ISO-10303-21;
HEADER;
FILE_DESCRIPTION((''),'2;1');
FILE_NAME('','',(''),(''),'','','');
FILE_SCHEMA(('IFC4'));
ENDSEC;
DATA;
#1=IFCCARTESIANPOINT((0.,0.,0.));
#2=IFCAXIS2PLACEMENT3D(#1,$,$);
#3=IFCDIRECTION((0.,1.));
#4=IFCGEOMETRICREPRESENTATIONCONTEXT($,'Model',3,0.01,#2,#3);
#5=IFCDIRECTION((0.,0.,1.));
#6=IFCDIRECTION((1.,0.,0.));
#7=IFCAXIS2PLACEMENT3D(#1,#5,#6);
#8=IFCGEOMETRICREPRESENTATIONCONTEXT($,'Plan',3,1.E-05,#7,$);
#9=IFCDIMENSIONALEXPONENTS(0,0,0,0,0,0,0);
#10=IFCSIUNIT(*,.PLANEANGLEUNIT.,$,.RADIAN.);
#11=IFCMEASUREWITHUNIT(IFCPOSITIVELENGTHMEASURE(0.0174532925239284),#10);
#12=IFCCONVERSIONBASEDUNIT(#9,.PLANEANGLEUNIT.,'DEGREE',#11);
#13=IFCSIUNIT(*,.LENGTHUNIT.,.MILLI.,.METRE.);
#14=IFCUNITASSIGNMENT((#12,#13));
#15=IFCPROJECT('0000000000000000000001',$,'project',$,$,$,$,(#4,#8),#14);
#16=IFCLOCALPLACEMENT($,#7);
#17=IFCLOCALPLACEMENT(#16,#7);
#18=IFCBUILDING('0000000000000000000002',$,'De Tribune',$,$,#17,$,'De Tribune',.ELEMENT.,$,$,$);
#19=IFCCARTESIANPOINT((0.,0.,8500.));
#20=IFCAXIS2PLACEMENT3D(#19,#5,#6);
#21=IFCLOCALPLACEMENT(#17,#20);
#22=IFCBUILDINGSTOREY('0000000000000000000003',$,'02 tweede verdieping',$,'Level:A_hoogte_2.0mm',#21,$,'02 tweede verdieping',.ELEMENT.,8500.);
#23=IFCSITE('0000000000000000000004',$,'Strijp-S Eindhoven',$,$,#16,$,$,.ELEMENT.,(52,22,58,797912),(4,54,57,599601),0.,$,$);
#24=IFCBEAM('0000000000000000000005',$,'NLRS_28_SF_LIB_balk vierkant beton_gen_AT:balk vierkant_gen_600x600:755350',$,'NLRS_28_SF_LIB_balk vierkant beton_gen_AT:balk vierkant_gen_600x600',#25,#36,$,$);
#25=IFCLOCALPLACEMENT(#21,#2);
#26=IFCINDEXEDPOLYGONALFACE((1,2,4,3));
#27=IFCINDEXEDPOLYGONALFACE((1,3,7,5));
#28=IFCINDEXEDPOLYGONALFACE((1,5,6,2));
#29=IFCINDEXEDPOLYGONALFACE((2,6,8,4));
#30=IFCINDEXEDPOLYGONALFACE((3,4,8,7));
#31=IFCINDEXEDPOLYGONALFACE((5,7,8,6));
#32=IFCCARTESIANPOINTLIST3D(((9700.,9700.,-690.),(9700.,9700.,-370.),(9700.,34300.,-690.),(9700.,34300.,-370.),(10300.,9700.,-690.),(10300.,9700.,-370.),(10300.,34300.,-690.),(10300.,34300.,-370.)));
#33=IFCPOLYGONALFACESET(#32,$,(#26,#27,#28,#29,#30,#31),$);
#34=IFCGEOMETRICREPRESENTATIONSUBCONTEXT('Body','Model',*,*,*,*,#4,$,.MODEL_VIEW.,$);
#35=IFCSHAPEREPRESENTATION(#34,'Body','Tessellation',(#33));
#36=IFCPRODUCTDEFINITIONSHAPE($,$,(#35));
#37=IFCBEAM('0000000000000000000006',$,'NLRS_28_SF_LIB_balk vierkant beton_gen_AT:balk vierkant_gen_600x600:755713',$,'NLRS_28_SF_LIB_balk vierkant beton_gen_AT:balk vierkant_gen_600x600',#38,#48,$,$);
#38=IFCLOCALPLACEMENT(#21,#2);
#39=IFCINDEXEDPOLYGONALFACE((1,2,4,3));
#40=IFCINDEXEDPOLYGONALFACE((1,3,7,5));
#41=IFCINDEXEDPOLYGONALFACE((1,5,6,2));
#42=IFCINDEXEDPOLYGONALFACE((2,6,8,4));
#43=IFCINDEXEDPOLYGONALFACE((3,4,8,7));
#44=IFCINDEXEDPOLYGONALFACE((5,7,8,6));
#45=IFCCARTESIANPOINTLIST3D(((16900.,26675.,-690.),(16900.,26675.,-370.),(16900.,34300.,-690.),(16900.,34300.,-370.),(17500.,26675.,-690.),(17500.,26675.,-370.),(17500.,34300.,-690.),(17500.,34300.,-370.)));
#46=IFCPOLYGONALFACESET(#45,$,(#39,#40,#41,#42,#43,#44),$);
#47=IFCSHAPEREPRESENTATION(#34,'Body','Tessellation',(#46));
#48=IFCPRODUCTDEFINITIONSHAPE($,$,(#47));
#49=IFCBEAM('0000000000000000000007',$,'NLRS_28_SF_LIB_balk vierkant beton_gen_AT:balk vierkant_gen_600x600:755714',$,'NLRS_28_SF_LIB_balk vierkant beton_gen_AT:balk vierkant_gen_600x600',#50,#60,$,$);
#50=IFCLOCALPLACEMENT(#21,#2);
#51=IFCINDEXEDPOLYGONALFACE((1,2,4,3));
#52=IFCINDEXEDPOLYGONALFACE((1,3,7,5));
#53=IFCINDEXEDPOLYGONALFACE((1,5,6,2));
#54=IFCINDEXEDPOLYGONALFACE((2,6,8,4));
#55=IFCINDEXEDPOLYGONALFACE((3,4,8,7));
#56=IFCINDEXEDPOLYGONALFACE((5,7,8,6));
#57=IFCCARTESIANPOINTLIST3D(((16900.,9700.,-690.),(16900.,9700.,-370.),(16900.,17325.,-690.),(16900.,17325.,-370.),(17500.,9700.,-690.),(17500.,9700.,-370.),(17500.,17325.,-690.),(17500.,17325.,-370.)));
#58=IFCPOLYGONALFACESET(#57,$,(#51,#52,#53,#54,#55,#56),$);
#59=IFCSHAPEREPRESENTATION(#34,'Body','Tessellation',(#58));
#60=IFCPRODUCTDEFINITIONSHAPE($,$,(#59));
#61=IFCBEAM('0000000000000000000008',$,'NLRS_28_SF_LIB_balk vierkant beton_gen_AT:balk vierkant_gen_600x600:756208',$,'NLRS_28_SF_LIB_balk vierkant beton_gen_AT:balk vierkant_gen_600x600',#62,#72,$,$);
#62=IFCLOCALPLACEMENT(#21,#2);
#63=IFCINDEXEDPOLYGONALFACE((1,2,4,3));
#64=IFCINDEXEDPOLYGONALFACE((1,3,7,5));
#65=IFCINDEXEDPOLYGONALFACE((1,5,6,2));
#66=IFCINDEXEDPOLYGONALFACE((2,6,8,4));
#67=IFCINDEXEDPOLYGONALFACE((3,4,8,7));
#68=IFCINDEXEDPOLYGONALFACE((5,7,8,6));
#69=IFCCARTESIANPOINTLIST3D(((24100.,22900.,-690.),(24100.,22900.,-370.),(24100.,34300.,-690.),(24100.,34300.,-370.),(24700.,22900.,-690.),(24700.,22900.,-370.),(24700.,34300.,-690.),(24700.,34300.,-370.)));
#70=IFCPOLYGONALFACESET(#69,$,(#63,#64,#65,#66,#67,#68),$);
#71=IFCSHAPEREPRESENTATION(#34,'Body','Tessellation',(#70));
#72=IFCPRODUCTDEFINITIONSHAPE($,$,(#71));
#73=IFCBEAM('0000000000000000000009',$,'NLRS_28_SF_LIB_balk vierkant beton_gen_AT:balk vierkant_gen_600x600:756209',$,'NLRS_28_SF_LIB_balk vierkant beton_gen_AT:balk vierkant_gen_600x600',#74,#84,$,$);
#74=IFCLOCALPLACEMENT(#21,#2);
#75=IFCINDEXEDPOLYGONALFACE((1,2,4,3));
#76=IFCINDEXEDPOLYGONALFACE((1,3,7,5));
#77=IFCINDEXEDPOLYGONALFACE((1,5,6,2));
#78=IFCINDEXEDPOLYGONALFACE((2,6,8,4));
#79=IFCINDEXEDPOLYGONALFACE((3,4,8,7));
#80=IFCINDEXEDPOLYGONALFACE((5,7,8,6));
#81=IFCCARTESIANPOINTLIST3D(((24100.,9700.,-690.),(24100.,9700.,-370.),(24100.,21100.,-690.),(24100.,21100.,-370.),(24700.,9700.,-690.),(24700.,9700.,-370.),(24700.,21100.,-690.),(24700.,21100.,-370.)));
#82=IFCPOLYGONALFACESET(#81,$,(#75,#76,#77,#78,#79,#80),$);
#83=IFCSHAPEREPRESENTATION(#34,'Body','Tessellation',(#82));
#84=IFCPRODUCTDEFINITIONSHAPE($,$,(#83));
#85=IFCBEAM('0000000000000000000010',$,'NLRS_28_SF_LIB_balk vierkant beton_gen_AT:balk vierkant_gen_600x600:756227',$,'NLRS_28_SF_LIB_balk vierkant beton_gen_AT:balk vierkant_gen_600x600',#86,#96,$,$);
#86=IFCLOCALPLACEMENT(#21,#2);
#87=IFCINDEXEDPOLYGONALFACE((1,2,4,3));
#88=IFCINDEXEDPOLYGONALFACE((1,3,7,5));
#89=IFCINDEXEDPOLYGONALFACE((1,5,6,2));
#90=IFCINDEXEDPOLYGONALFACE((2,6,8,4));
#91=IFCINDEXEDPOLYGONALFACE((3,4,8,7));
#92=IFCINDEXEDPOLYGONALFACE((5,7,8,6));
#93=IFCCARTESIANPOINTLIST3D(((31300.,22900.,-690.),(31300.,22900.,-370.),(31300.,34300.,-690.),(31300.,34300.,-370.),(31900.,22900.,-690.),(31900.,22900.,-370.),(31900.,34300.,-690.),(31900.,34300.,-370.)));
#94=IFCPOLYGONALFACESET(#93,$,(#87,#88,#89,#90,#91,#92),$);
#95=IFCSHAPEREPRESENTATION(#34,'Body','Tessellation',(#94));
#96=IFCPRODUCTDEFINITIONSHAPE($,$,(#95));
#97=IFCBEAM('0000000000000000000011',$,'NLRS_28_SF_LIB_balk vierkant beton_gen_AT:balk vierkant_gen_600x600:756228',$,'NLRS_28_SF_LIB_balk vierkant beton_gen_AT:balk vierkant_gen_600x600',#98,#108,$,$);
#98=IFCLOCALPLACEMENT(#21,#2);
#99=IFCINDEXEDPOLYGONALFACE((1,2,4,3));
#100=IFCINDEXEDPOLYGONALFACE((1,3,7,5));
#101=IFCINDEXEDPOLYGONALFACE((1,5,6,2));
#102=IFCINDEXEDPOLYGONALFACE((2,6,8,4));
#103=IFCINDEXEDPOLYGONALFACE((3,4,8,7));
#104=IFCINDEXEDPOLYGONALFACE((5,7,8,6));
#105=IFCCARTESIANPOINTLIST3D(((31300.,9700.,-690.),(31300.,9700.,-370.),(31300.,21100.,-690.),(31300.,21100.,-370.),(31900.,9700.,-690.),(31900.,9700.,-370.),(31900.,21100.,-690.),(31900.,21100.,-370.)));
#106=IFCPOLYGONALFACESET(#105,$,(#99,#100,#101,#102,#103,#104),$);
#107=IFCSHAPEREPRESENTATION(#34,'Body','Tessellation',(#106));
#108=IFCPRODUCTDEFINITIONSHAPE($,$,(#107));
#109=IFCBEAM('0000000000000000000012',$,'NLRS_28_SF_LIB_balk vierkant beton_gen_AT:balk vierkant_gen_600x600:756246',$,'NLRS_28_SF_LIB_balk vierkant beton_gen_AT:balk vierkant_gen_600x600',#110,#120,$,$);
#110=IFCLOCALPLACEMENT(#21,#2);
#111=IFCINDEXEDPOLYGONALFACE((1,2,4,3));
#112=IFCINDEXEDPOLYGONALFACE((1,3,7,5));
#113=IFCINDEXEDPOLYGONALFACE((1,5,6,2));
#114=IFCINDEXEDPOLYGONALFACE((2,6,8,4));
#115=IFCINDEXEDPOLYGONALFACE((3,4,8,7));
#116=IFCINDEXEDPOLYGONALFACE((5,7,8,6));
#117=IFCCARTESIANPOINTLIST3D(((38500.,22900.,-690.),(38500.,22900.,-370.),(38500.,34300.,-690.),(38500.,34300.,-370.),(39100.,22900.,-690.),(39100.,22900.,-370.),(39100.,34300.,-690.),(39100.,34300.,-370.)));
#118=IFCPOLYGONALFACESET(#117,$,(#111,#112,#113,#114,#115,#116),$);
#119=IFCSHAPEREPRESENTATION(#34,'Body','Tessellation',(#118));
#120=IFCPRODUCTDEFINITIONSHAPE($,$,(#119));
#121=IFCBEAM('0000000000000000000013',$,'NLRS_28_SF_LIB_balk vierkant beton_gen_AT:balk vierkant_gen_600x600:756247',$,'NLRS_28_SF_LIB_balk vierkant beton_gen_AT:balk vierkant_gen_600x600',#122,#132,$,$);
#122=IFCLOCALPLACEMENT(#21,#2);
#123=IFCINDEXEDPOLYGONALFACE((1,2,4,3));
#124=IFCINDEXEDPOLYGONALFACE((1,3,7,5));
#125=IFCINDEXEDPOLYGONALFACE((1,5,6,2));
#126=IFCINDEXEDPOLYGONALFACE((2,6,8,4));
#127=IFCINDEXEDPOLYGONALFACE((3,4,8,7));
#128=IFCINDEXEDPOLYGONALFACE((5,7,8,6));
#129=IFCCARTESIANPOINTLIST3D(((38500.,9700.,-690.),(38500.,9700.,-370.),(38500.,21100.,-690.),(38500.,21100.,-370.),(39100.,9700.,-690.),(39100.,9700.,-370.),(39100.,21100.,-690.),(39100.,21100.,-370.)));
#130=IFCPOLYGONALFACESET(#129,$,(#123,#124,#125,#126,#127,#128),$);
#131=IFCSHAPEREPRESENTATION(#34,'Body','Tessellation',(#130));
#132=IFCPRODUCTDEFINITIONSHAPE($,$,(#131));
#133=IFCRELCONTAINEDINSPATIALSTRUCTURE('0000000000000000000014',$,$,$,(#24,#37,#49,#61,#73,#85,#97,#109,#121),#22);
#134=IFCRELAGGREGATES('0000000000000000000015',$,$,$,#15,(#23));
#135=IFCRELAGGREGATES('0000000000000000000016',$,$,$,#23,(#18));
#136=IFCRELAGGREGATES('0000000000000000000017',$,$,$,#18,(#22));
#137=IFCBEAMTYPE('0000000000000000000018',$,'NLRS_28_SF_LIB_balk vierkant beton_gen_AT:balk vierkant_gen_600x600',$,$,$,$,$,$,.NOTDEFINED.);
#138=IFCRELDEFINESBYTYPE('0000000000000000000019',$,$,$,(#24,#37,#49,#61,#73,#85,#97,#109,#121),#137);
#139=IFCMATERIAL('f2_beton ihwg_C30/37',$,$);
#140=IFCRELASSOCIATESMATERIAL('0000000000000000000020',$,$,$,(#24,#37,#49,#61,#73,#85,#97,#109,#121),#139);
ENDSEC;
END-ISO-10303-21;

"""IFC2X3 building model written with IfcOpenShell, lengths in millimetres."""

from ifc_helpers import new_model, entity, si_unit, converted_unit, direction, frame, frame_2d, origin, origin_with_axes, place, context, subcontext, project, spatial, rectangle, extrude, material, type_object, element, save


model = new_model("IFC2X3")

# Units and contexts
model_context = context("Model", 3, precision=0.01, world=origin(), true_north=direction((0.0, 1.0)))
plan_context = context("Plan", 3, precision=1e-05, world=origin_with_axes())
body_context = subcontext(model_context, "Body", "Model", "MODEL_VIEW")
ifc_project = project(units=[converted_unit("PLANEANGLEUNIT", "DEGREE", entity("IfcPositiveLengthMeasure", 0.0174532925239284), si_unit("PLANEANGLEUNIT", "RADIAN"), dimensions=[0, 0, 0, 0, 0, 0, 0]), si_unit("LENGTHUNIT", "METRE", prefix="MILLI")], contexts=[model_context, plan_context])

# Site, building, storey
site_placement = place(None, origin_with_axes())
site = spatial("IfcSite", under=ifc_project, at=site_placement, Name="Strijp-S Eindhoven", CompositionType="ELEMENT", RefLatitude=(52, 22, 58, 797912), RefLongitude=(4, 54, 57, 599601), RefElevation=0.0)
building_placement = place(site_placement, origin_with_axes())
building = spatial("IfcBuilding", under=site, at=building_placement, Name="De Tribune", LongName="De Tribune", CompositionType="ELEMENT")
storey_placement = place(building_placement, frame((0.0, 0.0, 8500.0), z_axis=(0.0, 0.0, 1.0), x_axis=(1.0, 0.0, 0.0)))
storey = spatial("IfcBuildingStorey", under=building, at=storey_placement, Name="02 tweede verdieping", ObjectType="Level:A_hoogte_2.0mm", LongName="02 tweede verdieping", CompositionType="ELEMENT", Elevation=8500.0)

# Beams
ifc_material = material(Name="f2_beton ihwg_C30/37")
beam_type = type_object("IfcBeamType", Name="NLRS_28_SF_LIB_balk vierkant beton_gen_AT:balk vierkant_gen_600x600", PredefinedType="NOTDEFINED")
beam_placement = place(storey_placement, frame((10000.0, 34300.0, 0.0), z_axis=(0.0, 0.0, 1.0), x_axis=(0.0, -1.0, 0.0)))
element("IfcBeam", 1, at=beam_placement, inside=storey, type_object=beam_type, material=ifc_material, Name="NLRS_28_SF_LIB_balk vierkant beton_gen_AT:balk vierkant_gen_600x600:755350", ObjectType="NLRS_28_SF_LIB_balk vierkant beton_gen_AT:balk vierkant_gen_600x600", context=body_context, shape_type="SweptSolid", body=[
    extrude(rectangle(XDim=320.0, YDim=600.0, at=frame_2d((0.0, 0.0), x_axis=(1.0, 0.0))), frame((0.0, 0.0, -530.0), z_axis=(1.0, 0.0, 0.0), x_axis=(0.0, 0.0, -1.0)), (0.0, 0.0, 1.0), 24600.0),
])
for number, where, z_axis, x_axis, name in (
    (2, (17200.0, 34300.0, 0.0), (0.0, 0.0, 1.0), (0.0, -1.0, 0.0), "NLRS_28_SF_LIB_balk vierkant beton_gen_AT:balk vierkant_gen_600x600:755713"),
    (3, (17200.0, 17325.0, 0.0), (0.0, 0.0, 1.0), (0.0, -1.0, 0.0), "NLRS_28_SF_LIB_balk vierkant beton_gen_AT:balk vierkant_gen_600x600:755714"),
):
    element("IfcBeam", number, at=place(storey_placement, frame(where, z_axis=z_axis, x_axis=x_axis)), inside=storey, type_object=beam_type, material=ifc_material, Name=name, ObjectType="NLRS_28_SF_LIB_balk vierkant beton_gen_AT:balk vierkant_gen_600x600", context=body_context, shape_type="SweptSolid", body=[
        extrude(rectangle(XDim=320.0, YDim=600.0, at=frame_2d((0.0, 0.0), x_axis=(1.0, 0.0))), frame((0.0, 0.0, -530.0), z_axis=(1.0, 0.0, 0.0), x_axis=(0.0, 0.0, -1.0)), (0.0, 0.0, 1.0), 7625.0),
    ])
for number, where, z_axis, x_axis, name in (
    (4, (24400.0, 34300.0, 0.0), (0.0, 0.0, 1.0), (0.0, -1.0, 0.0), "NLRS_28_SF_LIB_balk vierkant beton_gen_AT:balk vierkant_gen_600x600:756208"),
    (5, (24400.0, 21100.0, 0.0), (0.0, 0.0, 1.0), (0.0, -1.0, 0.0), "NLRS_28_SF_LIB_balk vierkant beton_gen_AT:balk vierkant_gen_600x600:756209"),
    (6, (31600.0, 34300.0, 0.0), (0.0, 0.0, 1.0), (0.0, -1.0, 0.0), "NLRS_28_SF_LIB_balk vierkant beton_gen_AT:balk vierkant_gen_600x600:756227"),
    (7, (31600.0, 21100.0, 0.0), (0.0, 0.0, 1.0), (0.0, -1.0, 0.0), "NLRS_28_SF_LIB_balk vierkant beton_gen_AT:balk vierkant_gen_600x600:756228"),
    (8, (38800.0, 34300.0, 0.0), (0.0, 0.0, 1.0), (0.0, -1.0, 0.0), "NLRS_28_SF_LIB_balk vierkant beton_gen_AT:balk vierkant_gen_600x600:756246"),
    (9, (38800.0, 21100.0, 0.0), (0.0, 0.0, 1.0), (0.0, -1.0, 0.0), "NLRS_28_SF_LIB_balk vierkant beton_gen_AT:balk vierkant_gen_600x600:756247"),
):
    element("IfcBeam", number, at=place(storey_placement, frame(where, z_axis=z_axis, x_axis=x_axis)), inside=storey, type_object=beam_type, material=ifc_material, Name=name, ObjectType="NLRS_28_SF_LIB_balk vierkant beton_gen_AT:balk vierkant_gen_600x600", context=body_context, shape_type="SweptSolid", body=[
        extrude(rectangle(XDim=320.0, YDim=600.0, at=frame_2d((0.0, 0.0), x_axis=(1.0, 0.0))), frame((0.0, 0.0, -530.0), z_axis=(1.0, 0.0, 0.0), x_axis=(0.0, 0.0, -1.0)), (0.0, 0.0, 1.0), 11400.0),
    ])

save(model, "model.ifc")
